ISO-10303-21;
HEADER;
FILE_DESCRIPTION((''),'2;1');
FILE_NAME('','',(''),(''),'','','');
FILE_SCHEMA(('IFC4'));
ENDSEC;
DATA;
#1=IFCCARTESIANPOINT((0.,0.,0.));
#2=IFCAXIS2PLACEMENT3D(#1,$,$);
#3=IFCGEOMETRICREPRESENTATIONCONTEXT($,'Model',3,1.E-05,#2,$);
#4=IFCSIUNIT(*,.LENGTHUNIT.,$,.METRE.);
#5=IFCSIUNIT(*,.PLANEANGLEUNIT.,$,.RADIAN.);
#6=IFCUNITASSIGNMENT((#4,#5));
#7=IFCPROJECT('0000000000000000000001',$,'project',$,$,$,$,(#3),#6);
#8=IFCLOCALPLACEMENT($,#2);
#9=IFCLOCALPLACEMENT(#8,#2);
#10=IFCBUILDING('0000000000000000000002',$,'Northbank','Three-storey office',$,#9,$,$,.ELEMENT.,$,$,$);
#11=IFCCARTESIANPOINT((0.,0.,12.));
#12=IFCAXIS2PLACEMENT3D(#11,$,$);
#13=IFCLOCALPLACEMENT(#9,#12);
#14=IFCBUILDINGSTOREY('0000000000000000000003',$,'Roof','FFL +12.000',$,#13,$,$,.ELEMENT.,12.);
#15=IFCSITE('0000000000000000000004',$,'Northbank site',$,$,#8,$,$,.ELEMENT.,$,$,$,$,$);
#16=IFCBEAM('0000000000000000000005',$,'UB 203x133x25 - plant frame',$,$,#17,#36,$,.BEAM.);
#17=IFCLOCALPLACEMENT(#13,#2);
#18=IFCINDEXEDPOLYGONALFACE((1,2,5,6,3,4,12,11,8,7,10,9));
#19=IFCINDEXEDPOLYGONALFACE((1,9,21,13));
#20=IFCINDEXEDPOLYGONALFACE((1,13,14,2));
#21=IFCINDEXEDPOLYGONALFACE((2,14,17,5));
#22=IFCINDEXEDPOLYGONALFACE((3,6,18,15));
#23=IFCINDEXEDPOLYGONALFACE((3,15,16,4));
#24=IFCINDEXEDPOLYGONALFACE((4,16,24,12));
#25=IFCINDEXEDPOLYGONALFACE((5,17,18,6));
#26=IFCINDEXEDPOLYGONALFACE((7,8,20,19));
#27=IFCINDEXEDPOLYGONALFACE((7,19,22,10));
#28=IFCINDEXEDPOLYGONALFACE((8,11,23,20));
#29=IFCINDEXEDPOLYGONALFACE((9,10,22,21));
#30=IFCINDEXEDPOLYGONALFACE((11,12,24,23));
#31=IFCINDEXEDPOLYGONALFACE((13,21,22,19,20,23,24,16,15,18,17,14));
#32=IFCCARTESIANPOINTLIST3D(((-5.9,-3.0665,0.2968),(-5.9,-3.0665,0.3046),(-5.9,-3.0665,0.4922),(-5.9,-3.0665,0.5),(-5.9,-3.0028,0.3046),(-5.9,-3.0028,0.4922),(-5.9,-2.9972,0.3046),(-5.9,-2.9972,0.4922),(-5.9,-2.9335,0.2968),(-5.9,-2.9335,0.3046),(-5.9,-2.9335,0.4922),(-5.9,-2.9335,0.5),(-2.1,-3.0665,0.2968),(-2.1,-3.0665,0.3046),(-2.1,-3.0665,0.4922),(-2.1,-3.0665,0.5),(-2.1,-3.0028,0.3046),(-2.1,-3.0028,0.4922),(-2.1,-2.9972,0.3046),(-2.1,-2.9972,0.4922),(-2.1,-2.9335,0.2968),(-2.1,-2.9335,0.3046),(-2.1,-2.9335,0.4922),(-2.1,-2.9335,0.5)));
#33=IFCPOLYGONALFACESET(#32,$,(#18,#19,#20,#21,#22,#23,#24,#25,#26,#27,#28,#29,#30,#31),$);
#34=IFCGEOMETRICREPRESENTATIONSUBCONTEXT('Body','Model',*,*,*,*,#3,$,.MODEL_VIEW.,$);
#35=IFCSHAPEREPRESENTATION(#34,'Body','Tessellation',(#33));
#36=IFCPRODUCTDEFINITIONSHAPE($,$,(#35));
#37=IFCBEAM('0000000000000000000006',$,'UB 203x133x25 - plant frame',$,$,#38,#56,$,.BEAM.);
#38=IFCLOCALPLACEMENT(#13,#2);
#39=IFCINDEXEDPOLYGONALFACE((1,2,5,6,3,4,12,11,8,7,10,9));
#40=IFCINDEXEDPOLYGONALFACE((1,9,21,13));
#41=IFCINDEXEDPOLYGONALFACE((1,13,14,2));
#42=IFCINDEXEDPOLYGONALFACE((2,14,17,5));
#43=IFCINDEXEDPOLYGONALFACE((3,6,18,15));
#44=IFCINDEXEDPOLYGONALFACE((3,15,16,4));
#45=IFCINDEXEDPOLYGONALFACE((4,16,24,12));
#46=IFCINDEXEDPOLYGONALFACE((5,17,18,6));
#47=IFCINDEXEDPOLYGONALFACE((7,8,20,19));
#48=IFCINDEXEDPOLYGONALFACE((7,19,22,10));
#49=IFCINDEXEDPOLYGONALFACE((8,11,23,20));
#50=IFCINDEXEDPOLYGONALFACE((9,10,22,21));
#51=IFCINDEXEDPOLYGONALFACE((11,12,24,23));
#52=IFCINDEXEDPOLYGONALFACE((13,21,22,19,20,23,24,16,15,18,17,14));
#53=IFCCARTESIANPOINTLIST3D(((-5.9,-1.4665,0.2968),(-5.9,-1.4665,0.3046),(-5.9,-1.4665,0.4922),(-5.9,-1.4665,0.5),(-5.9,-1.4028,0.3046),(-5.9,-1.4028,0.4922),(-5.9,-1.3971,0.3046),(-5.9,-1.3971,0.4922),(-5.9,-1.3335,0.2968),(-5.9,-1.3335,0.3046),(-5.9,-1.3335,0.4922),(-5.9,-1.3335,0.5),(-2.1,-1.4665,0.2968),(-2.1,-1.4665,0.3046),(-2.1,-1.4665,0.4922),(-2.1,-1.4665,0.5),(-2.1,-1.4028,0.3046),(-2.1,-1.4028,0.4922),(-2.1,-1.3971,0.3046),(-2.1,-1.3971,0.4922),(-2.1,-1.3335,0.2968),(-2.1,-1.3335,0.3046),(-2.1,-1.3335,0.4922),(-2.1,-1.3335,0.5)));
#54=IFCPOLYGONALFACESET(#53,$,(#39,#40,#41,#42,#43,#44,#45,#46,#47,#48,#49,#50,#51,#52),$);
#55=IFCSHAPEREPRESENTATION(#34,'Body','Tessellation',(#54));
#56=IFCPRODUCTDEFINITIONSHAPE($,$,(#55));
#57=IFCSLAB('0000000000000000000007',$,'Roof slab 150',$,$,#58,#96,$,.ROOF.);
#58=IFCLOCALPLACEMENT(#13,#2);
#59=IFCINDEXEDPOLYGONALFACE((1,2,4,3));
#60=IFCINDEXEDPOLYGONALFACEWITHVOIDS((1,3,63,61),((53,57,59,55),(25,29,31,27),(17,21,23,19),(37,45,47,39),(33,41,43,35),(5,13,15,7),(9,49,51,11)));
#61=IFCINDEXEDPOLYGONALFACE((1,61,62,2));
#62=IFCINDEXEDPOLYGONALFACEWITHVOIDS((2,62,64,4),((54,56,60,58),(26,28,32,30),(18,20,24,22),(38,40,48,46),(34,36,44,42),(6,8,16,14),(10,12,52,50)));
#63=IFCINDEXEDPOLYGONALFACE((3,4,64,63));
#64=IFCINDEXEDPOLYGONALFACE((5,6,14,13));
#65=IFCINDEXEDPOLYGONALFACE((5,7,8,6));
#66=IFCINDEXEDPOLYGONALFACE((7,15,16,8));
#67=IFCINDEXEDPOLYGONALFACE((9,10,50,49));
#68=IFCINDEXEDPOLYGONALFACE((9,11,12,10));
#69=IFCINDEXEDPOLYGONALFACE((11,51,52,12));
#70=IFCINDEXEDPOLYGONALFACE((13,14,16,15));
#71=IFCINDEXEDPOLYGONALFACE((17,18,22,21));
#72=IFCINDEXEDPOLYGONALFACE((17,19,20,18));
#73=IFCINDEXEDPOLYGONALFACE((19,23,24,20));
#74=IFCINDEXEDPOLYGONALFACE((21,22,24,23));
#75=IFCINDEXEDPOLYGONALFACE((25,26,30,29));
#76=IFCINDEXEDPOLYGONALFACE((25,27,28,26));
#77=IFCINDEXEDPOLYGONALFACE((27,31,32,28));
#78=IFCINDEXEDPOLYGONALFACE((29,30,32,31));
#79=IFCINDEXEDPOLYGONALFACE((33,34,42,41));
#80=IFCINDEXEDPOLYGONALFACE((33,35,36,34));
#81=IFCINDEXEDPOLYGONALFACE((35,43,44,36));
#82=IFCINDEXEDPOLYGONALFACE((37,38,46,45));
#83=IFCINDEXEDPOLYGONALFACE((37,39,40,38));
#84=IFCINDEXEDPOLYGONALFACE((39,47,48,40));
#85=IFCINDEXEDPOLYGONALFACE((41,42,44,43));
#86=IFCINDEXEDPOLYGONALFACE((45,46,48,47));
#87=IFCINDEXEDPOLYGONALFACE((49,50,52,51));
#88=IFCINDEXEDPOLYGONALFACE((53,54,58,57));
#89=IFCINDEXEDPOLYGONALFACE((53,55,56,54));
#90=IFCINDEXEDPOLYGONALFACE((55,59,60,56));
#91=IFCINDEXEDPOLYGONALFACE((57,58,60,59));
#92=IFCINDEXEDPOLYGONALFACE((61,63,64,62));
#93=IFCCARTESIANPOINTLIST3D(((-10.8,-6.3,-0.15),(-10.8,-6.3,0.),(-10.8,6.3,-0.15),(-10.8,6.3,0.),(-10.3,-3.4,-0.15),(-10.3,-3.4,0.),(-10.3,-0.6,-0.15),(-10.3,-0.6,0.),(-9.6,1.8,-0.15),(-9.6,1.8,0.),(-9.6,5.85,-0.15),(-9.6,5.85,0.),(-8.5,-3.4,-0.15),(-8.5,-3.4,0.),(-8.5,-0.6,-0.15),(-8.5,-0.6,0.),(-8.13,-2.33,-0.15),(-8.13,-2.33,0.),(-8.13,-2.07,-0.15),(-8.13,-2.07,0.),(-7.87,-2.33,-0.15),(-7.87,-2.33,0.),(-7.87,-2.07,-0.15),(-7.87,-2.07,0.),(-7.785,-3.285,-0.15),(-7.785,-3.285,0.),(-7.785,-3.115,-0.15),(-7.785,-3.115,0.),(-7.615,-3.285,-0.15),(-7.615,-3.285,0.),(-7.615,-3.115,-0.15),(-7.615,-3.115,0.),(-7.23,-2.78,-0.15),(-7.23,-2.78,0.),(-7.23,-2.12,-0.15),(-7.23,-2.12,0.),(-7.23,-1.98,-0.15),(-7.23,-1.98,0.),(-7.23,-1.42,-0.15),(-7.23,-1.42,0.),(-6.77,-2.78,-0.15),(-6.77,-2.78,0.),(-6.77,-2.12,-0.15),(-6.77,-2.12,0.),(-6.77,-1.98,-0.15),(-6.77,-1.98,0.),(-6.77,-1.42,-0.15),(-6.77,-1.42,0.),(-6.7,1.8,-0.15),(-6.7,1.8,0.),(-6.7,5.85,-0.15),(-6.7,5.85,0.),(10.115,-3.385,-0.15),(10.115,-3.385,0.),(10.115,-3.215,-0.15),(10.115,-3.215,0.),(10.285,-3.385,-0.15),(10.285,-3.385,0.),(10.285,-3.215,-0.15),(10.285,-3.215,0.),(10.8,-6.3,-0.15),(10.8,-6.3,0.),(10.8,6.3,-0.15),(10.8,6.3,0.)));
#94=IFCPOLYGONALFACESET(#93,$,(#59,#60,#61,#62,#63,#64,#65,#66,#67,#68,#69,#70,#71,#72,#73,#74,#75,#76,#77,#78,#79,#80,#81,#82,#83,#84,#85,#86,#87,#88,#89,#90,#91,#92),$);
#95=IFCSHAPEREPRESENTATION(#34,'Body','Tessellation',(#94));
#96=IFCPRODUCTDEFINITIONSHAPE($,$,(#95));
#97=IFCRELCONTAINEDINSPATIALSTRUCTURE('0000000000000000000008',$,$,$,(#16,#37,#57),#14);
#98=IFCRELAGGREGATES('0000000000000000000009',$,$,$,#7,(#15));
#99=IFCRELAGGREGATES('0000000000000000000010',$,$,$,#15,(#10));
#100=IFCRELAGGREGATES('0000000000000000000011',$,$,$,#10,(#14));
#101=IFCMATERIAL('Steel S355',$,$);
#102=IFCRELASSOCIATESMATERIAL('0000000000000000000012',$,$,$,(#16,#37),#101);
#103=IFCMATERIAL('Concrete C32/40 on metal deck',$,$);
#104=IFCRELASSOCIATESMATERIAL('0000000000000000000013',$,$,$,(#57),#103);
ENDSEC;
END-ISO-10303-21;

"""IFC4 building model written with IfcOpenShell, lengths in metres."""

from ifc_helpers import new_model, si_unit, frame, origin, place, context, subcontext, project, spatial, polyline, i_section, outline, extrude, material, element, save


model = new_model("IFC4")

# Units and contexts
model_context = context("Model", 3, precision=1e-05, world=origin())
body_context = subcontext(model_context, "Body", "Model", "MODEL_VIEW")
ifc_project = project(units=[si_unit("LENGTHUNIT", "METRE"), si_unit("PLANEANGLEUNIT", "RADIAN")], contexts=[model_context])

# Site, building, storey
site_placement = place(None, origin())
site = spatial("IfcSite", under=ifc_project, at=site_placement, Name="Northbank site", CompositionType="ELEMENT")
building_placement = place(site_placement, origin())
building = spatial("IfcBuilding", under=site, at=building_placement, Name="Northbank", Description="Three-storey office", CompositionType="ELEMENT")
storey_placement = place(building_placement, frame((0.0, 0.0, 12.0)))
storey = spatial("IfcBuildingStorey", under=building, at=storey_placement, Name="Roof", Description="FFL +12.000", CompositionType="ELEMENT", Elevation=12.0)

# Shared definitions
ifc_material_1 = material(Name="Steel S355")

# Beams
beam_1_placement = place(storey_placement, frame((0.0, 0.0, -12.0)))
element("IfcBeam", 1, at=beam_1_placement, inside=storey, material=ifc_material_1, Name="UB 203x133x25 - plant frame", PredefinedType="BEAM", context=body_context, shape_type="SweptSolid", body=[
    extrude(i_section(OverallWidth=0.133, OverallDepth=0.2032, WebThickness=0.0057, FlangeThickness=0.0078), frame((-5.9, -3.0, 12.3984), z_axis=(1.0, 0.0, 0.0), x_axis=(0.0, 1.0, 0.0)), (0.0, 0.0, 1.0), 3.8),
])
beam_2_placement = place(storey_placement, frame((0.0, 0.0, -12.0)))
element("IfcBeam", 2, at=beam_2_placement, inside=storey, material=ifc_material_1, Name="UB 203x133x25 - plant frame", PredefinedType="BEAM", context=body_context, shape_type="SweptSolid", body=[
    extrude(i_section(OverallWidth=0.133, OverallDepth=0.2032, WebThickness=0.0057, FlangeThickness=0.0078), frame((-5.9, -1.4, 12.3984), z_axis=(1.0, 0.0, 0.0), x_axis=(0.0, 1.0, 0.0)), (0.0, 0.0, 1.0), 3.8),
])

# Slab
ifc_material_2 = material(Name="Concrete C32/40 on metal deck")
slab_placement = place(storey_placement, frame((0.0, 0.0, -12.0)))
element("IfcSlab", 3, at=slab_placement, inside=storey, material=ifc_material_2, Name="Roof slab 150", PredefinedType="ROOF", context=body_context, shape_type="SweptSolid", body=[
    extrude(outline(polyline([(-10.8, -6.3), (10.8, -6.3), (10.8, 6.3), (-10.8, 6.3), (-10.8, -6.3)]), holes=[polyline([(-10.3, -3.4), (-10.3, -0.6), (-8.5, -0.6), (-8.5, -3.4), (-10.3, -3.4)]), polyline([(-9.6, 1.8), (-9.6, 5.85), (-6.7, 5.85), (-6.7, 1.8), (-9.6, 1.8)]), polyline([(-7.23, -2.78), (-7.23, -2.12), (-6.77, -2.12), (-6.77, -2.78), (-7.23, -2.78)]), polyline([(-7.23, -1.98), (-7.23, -1.42), (-6.77, -1.42), (-6.77, -1.98), (-7.23, -1.98)]), polyline([(-8.13, -2.33), (-8.13, -2.07), (-7.87, -2.07), (-7.87, -2.33), (-8.13, -2.33)]), polyline([(-7.785, -3.285), (-7.785, -3.115), (-7.615, -3.115), (-7.615, -3.285), (-7.785, -3.285)]), polyline([(10.115, -3.385), (10.115, -3.215), (10.285, -3.215), (10.285, -3.385), (10.115, -3.385)])]), frame((0.0, 0.0, 11.85)), (0.0, 0.0, 1.0), 0.15),
])

save(model, "model.ifc")
